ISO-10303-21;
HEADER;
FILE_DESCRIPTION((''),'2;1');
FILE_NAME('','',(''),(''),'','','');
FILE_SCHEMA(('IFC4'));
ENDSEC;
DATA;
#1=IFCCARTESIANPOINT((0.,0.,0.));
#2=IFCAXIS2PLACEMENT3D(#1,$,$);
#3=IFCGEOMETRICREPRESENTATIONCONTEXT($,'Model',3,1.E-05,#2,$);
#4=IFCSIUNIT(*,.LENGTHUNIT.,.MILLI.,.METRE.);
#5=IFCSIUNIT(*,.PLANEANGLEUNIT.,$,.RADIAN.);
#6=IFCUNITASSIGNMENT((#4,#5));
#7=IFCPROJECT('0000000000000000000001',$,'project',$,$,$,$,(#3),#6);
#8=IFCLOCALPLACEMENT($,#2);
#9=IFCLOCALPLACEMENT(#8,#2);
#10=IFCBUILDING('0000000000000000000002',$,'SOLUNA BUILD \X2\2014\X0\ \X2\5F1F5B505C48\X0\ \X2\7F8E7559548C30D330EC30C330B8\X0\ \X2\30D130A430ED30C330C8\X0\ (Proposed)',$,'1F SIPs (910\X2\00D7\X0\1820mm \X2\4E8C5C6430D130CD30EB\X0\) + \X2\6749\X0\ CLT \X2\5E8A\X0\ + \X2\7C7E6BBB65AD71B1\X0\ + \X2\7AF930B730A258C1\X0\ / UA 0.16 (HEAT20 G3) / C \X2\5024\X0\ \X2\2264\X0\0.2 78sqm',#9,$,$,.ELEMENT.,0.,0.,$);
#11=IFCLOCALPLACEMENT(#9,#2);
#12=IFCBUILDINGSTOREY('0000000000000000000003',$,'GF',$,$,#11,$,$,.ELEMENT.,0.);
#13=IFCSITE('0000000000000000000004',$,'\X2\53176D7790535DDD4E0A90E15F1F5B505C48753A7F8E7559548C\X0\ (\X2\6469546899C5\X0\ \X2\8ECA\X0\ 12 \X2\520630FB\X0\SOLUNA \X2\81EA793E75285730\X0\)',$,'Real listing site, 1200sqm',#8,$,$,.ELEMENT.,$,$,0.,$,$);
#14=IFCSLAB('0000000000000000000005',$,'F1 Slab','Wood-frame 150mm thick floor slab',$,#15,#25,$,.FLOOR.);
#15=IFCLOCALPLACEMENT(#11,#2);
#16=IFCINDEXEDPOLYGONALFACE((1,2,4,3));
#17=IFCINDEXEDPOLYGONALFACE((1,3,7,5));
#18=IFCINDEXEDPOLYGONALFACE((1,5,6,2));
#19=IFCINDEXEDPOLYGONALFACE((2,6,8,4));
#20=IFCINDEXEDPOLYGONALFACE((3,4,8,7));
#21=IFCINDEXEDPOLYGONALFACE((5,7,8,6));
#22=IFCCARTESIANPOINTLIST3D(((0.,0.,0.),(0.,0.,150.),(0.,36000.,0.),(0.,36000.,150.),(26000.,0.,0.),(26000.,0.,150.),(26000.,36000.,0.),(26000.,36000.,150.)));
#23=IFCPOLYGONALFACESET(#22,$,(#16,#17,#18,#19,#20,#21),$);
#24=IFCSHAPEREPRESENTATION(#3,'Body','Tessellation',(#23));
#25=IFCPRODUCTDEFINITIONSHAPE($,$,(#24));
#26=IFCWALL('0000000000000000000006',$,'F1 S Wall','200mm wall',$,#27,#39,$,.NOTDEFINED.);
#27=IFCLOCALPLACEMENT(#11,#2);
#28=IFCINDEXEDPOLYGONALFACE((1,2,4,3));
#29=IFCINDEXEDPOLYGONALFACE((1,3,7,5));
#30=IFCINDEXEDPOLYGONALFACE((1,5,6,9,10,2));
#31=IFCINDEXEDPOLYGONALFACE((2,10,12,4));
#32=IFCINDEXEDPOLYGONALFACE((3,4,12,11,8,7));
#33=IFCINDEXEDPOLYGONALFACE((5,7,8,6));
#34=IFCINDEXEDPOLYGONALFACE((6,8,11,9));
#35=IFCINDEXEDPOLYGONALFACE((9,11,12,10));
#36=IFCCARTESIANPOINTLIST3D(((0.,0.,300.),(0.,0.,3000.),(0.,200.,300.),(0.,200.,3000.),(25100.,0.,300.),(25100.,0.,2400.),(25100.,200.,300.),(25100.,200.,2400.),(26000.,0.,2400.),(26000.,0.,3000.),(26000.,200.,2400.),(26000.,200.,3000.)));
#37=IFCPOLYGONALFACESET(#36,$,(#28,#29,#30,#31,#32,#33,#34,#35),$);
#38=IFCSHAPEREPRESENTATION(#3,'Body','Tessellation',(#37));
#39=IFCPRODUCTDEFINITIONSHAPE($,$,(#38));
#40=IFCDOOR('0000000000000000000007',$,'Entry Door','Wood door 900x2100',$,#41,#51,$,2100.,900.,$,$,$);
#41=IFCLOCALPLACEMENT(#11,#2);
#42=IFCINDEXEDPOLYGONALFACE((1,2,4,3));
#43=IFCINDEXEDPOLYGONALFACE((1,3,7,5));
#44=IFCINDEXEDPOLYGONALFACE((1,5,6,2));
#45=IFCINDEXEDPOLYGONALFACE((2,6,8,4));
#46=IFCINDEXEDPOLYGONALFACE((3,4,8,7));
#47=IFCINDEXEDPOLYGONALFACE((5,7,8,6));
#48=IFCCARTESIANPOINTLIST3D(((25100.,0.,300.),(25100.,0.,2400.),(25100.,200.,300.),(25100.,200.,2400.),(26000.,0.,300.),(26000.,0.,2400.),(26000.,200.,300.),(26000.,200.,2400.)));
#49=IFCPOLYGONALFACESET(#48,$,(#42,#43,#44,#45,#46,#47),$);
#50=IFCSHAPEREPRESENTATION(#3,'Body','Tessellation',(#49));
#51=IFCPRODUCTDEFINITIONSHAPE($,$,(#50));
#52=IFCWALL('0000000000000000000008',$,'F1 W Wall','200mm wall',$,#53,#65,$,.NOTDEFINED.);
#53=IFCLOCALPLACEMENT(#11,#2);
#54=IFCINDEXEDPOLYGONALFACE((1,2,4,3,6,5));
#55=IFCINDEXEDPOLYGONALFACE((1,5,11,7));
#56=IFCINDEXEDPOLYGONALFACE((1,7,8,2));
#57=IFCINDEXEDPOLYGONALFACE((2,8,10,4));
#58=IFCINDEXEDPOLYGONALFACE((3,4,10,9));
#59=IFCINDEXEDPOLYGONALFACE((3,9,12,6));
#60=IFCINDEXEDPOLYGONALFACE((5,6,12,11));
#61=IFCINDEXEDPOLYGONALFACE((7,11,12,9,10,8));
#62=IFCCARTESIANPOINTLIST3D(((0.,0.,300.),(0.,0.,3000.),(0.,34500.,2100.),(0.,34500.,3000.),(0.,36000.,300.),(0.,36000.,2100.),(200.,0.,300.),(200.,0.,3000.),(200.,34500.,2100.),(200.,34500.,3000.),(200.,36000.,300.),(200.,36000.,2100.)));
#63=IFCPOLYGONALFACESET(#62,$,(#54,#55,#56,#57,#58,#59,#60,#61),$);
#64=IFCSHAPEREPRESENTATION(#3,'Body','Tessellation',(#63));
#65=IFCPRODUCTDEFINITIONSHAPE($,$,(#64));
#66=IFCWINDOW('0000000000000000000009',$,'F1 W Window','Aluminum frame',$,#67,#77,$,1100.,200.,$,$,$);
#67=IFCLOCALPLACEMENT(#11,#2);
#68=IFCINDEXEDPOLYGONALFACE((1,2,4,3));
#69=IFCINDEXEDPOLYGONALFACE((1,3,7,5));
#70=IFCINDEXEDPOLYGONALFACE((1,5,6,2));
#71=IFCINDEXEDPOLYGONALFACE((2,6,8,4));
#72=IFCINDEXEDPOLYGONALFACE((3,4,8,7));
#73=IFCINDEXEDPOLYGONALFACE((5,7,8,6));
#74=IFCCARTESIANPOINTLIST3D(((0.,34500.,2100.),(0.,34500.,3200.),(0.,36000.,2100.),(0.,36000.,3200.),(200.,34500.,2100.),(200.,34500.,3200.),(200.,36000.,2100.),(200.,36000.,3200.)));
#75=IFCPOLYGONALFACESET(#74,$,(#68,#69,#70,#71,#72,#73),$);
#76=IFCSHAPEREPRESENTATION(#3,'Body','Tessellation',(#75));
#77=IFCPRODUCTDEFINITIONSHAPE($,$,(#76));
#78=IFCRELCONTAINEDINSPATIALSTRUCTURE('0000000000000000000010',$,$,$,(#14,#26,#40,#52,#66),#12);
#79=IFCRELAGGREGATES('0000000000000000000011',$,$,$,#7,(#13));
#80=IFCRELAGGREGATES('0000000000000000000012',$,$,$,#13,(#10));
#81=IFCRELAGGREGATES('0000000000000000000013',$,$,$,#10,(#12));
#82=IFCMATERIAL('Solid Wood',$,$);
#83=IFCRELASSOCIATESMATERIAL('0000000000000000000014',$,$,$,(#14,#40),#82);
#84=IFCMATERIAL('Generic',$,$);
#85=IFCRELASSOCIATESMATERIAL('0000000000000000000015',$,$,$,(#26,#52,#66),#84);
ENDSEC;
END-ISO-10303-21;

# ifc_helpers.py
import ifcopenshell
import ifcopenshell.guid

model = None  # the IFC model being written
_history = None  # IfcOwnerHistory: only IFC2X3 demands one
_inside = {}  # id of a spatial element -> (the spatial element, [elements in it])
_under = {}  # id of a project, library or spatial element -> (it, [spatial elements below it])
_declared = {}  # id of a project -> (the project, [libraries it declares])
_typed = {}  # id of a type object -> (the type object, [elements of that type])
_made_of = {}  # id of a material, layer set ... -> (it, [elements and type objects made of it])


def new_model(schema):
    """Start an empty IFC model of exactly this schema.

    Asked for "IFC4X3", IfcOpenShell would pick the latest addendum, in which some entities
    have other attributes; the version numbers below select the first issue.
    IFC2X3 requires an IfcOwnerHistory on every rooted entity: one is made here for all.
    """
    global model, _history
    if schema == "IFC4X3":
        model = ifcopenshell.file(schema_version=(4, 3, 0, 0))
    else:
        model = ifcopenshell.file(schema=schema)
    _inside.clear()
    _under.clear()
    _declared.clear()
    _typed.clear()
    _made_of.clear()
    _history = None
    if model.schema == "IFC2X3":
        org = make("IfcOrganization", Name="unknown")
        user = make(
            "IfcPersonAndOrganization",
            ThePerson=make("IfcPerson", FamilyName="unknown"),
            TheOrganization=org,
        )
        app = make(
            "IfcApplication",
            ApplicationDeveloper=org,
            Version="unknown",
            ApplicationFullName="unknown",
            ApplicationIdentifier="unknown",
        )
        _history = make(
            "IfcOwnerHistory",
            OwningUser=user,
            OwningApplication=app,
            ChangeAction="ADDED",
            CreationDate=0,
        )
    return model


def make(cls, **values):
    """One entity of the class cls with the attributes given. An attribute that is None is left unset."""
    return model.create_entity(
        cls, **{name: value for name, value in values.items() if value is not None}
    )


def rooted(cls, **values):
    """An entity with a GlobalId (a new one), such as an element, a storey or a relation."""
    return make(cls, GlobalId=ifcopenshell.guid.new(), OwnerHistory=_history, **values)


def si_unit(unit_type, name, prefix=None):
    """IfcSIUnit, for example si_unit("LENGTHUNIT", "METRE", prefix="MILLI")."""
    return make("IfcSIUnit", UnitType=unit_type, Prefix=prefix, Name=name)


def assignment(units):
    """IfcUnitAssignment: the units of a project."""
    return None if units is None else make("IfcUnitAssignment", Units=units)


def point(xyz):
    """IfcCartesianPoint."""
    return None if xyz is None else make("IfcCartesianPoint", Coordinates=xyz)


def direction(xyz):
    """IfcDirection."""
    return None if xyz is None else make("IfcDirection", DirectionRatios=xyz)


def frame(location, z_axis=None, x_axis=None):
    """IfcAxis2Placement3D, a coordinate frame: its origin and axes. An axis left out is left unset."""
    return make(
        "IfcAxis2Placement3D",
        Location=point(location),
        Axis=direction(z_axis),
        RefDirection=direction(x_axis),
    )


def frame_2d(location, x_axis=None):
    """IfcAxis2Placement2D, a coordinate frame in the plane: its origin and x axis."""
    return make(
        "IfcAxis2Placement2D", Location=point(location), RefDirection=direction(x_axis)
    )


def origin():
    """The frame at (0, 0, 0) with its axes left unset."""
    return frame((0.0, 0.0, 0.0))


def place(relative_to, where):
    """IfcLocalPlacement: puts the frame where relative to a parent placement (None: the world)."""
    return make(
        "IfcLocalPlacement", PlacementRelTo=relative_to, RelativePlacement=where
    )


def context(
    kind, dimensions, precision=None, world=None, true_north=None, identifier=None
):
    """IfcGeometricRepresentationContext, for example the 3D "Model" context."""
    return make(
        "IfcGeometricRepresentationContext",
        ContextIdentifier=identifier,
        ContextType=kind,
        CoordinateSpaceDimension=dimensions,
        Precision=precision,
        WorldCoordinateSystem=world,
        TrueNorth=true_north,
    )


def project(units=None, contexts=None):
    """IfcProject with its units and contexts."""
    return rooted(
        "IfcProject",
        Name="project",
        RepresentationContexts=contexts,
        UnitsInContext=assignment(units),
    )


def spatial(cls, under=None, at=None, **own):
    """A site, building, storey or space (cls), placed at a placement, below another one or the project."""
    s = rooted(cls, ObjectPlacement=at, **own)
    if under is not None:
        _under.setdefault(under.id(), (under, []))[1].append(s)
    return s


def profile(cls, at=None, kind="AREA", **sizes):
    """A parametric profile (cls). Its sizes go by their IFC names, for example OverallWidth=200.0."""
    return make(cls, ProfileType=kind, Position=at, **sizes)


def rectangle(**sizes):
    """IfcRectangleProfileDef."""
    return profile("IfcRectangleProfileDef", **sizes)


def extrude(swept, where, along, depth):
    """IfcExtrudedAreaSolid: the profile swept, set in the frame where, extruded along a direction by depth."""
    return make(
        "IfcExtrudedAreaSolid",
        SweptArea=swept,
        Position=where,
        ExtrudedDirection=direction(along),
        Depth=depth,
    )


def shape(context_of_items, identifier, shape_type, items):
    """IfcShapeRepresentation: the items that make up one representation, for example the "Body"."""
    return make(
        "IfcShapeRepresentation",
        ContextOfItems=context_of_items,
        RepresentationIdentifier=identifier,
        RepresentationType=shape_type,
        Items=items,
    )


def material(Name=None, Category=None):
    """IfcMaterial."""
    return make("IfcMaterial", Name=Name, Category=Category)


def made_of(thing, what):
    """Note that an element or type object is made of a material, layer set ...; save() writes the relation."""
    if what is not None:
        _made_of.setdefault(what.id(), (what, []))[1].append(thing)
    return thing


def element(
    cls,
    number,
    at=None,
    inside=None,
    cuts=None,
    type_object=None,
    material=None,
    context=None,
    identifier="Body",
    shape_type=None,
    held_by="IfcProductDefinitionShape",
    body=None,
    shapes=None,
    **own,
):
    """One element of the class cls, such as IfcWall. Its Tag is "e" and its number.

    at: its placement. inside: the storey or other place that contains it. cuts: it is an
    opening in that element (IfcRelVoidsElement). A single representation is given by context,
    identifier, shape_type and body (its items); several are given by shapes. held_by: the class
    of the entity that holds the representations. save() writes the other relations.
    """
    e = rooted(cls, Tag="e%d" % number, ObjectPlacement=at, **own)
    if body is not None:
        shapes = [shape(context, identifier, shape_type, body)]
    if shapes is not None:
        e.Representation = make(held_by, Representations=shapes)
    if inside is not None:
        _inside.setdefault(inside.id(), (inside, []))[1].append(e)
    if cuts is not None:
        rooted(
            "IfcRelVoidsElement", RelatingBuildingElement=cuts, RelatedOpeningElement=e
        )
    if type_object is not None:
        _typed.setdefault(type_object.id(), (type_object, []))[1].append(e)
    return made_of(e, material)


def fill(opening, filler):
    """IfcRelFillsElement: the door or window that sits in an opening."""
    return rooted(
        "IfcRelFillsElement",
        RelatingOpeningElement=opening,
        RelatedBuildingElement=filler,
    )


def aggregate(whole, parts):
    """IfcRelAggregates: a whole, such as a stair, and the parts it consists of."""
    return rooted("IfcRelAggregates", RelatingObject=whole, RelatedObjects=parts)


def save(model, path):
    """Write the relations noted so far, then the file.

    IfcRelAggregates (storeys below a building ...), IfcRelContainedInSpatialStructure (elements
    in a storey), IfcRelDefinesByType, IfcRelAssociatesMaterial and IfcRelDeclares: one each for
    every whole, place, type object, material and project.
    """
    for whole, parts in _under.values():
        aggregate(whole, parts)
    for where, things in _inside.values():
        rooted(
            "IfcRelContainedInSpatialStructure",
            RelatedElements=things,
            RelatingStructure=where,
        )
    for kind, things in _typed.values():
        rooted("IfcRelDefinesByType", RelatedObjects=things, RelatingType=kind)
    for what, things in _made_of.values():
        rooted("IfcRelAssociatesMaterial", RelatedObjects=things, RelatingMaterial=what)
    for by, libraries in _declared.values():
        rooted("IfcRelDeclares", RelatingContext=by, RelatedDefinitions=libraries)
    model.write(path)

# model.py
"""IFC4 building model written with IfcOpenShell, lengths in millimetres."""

from ifc_helpers import new_model, si_unit, frame, frame_2d, origin, place, context, project, spatial, rectangle, extrude, material, element, fill, save


model = new_model("IFC4")

# Units and contexts
model_context = context("Model", 3, precision=1e-05, world=origin())
ifc_project = project(units=[si_unit("LENGTHUNIT", "METRE", prefix="MILLI"), si_unit("PLANEANGLEUNIT", "RADIAN")], contexts=[model_context])

# Site, building, storey
site_placement = place(None, origin())
site = spatial("IfcSite", under=ifc_project, at=site_placement, Name="北海道川上郡弟子屈町美留和 (摩周駅 車 12 分・SOLUNA 自社用地)", ObjectType="Real listing site, 1200sqm", CompositionType="ELEMENT", RefElevation=0.0)
building_placement = place(site_placement, origin())
building = spatial("IfcBuilding", under=site, at=building_placement, Name="SOLUNA BUILD — 弟子屈 美留和ビレッジ パイロット (Proposed)", ObjectType="1F SIPs (910×1820mm 二層パネル) + 杉 CLT 床 + 籾殻断熱 + 竹シア壁 / UA 0.16 (HEAT20 G3) / C 値 ≤0.2 78sqm", CompositionType="ELEMENT", ElevationOfRefHeight=0.0, ElevationOfTerrain=0.0)
storey_placement = place(building_placement, origin())
storey = spatial("IfcBuildingStorey", under=building, at=storey_placement, Name="GF", CompositionType="ELEMENT", Elevation=0.0)

# Slab
ifc_material_1 = material(Name="Solid Wood")
slab_placement = place(storey_placement, origin())
element("IfcSlab", 1, at=slab_placement, inside=storey, material=ifc_material_1, Name="F1 Slab", Description="Wood-frame 150mm thick floor slab", PredefinedType="FLOOR", context=model_context, shape_type="SweptSolid", body=[
    extrude(rectangle(XDim=26000.0, YDim=36000.0, at=frame_2d((13000.0, 18000.0))), origin(), (0.0, 0.0, 1.0), 150.0),
])

# Shared definitions
ifc_material_2 = material(Name="Generic")

# Wall, opening, door
wall_1_placement = place(storey_placement, frame((0.0, 0.0, 150.0)))
wall_1 = element("IfcWall", 2, at=wall_1_placement, inside=storey, material=ifc_material_2, Name="F1 S Wall", Description="200mm wall", PredefinedType="NOTDEFINED", context=model_context, shape_type="SweptSolid", body=[
    extrude(rectangle(XDim=26000.0, YDim=200.0, at=frame_2d((13000.0, 100.0))), frame((0.0, 0.0, 150.0)), (0.0, 0.0, 1.0), 2700.0),
])
opening_1_placement = place(storey_placement, frame((12550.0, 0.0, 150.0)))
opening_1 = element("IfcOpeningElement", 3, at=opening_1_placement, cuts=wall_1, PredefinedType="NOTDEFINED", context=model_context, shape_type="SweptSolid", body=[
    extrude(rectangle(XDim=900.0, YDim=200.0, at=frame_2d((450.0, 100.0))), frame((12550.0, 0.0, 150.0)), (0.0, 0.0, 1.0), 2100.0),
])
door_placement = place(storey_placement, frame((12550.0, 0.0, 150.0)))
door = element("IfcDoor", 4, at=door_placement, inside=storey, material=ifc_material_1, Name="Entry Door", Description="Wood door 900x2100", OverallHeight=2100.0, OverallWidth=900.0, context=model_context, shape_type="SweptSolid", body=[
    extrude(rectangle(XDim=900.0, YDim=200.0, at=frame_2d((450.0, 100.0))), frame((12550.0, 0.0, 150.0)), (0.0, 0.0, 1.0), 2100.0),
])
fill(opening_1, door)

# Wall, opening, window
wall_2_placement = place(storey_placement, frame((0.0, 0.0, 150.0)))
wall_2 = element("IfcWall", 5, at=wall_2_placement, inside=storey, material=ifc_material_2, Name="F1 W Wall", Description="200mm wall", PredefinedType="NOTDEFINED", context=model_context, shape_type="SweptSolid", body=[
    extrude(rectangle(XDim=200.0, YDim=36000.0, at=frame_2d((100.0, 18000.0))), frame((0.0, 0.0, 150.0)), (0.0, 0.0, 1.0), 2700.0),
])
opening_2_placement = place(storey_placement, frame((0.0, 17250.0, 1050.0)))
opening_2 = element("IfcOpeningElement", 6, at=opening_2_placement, cuts=wall_2, PredefinedType="NOTDEFINED", context=model_context, shape_type="SweptSolid", body=[
    extrude(rectangle(XDim=200.0, YDim=1500.0, at=frame_2d((100.0, 750.0))), frame((0.0, 17250.0, 1050.0)), (0.0, 0.0, 1.0), 1100.0),
])
window_1_placement = place(storey_placement, frame((0.0, 17250.0, 1050.0)))
window_1 = element("IfcWindow", 7, at=window_1_placement, inside=storey, material=ifc_material_2, Name="F1 W Window", Description="Aluminum frame", OverallHeight=1100.0, OverallWidth=200.0, context=model_context, shape_type="SweptSolid", body=[
    extrude(rectangle(XDim=200.0, YDim=1500.0, at=frame_2d((100.0, 750.0))), frame((0.0, 17250.0, 1050.0)), (0.0, 0.0, 1.0), 1100.0),
])
fill(opening_2, window_1)

save(model, "model.ifc")
